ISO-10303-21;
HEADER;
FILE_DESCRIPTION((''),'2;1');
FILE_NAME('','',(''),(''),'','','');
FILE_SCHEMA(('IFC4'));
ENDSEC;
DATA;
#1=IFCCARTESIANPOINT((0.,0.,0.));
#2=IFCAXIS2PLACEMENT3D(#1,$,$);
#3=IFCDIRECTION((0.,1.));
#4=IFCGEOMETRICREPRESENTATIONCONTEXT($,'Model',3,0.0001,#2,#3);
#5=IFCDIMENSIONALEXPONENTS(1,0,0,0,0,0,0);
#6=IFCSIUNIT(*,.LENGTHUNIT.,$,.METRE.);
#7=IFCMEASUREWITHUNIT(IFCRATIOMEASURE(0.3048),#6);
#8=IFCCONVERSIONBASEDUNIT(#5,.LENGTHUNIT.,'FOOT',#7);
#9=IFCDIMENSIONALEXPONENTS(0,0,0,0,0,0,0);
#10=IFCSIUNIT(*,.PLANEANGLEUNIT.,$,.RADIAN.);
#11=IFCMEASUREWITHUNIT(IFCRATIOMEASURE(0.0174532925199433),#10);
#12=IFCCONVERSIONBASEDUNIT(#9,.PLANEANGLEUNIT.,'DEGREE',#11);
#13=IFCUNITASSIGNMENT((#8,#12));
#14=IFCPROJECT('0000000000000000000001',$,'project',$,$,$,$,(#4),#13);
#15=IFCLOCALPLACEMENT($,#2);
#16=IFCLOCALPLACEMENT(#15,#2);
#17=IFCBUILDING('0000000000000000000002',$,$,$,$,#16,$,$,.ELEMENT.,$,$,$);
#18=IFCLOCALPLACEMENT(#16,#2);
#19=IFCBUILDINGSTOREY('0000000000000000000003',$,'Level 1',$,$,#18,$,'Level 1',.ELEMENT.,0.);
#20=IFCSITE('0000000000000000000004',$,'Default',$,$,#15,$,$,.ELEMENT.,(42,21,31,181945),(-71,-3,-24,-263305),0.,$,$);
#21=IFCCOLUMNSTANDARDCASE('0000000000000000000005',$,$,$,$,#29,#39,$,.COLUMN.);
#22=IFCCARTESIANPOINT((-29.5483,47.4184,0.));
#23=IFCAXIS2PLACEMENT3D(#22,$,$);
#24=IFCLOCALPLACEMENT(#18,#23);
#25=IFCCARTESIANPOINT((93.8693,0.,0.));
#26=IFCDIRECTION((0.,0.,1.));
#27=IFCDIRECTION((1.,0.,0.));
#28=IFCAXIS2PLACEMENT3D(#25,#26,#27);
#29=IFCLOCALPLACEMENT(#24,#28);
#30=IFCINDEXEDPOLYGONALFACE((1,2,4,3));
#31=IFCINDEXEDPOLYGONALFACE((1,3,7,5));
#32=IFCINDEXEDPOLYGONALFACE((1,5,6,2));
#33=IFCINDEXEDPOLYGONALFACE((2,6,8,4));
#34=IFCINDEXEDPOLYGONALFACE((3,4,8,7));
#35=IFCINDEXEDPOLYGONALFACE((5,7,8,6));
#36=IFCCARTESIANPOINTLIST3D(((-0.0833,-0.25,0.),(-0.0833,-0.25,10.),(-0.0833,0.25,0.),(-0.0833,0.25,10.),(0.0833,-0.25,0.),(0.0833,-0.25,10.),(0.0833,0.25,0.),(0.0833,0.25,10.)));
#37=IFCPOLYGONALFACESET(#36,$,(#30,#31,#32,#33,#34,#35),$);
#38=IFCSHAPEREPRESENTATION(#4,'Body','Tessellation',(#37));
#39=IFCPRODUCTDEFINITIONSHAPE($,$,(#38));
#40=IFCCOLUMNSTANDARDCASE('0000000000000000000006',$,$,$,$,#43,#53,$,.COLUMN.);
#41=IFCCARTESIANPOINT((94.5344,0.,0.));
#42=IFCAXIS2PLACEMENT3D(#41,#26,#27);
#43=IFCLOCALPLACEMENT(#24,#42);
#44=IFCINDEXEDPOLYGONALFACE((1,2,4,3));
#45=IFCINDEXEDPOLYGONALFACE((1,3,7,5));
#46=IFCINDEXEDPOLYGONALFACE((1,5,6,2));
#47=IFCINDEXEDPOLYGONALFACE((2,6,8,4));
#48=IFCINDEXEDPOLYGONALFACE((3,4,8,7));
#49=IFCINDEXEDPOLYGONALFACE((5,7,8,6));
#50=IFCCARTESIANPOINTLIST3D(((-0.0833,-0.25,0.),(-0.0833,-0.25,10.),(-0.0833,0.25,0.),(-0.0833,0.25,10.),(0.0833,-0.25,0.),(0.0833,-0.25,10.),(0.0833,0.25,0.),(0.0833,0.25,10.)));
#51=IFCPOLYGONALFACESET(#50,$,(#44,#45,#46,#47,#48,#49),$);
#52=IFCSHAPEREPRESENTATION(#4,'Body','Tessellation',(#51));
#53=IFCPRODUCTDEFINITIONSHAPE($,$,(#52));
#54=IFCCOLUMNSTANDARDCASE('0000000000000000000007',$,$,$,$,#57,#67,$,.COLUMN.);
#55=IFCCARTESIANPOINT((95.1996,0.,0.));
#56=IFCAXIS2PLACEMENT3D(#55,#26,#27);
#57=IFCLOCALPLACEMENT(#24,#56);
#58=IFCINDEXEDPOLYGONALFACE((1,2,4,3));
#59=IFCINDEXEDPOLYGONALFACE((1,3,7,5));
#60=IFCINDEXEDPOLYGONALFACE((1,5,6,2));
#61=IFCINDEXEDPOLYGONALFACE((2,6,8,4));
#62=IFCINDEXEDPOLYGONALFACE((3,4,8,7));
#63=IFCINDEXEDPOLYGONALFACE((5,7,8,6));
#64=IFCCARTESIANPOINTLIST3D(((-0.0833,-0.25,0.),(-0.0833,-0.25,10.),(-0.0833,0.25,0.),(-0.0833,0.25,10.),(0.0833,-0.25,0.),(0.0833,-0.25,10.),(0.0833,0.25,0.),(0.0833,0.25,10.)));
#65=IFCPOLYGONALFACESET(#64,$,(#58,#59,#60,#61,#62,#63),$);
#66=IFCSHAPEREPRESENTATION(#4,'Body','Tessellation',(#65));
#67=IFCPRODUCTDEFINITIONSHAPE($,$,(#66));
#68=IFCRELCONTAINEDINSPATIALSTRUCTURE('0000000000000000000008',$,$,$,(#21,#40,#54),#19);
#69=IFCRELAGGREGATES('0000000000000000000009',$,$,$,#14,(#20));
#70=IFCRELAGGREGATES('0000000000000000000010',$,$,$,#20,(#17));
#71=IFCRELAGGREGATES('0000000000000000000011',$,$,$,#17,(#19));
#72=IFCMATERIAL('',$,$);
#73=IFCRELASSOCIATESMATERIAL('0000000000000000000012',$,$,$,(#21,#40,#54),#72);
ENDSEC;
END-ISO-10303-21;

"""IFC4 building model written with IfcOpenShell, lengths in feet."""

from ifc_helpers import new_model, entity, si_unit, converted_unit, direction, frame, origin, place, context, project, spatial, rectangle, extrude, material, element, save


model = new_model("IFC4")

# Units and contexts
model_context = context("Model", 3, precision=0.0001, world=origin(), true_north=direction((0.0, 1.0)))
ifc_project = project(units=[converted_unit("LENGTHUNIT", "FOOT", entity("IfcRatioMeasure", 0.3048), si_unit("LENGTHUNIT", "METRE"), dimensions=[1, 0, 0, 0, 0, 0, 0]), converted_unit("PLANEANGLEUNIT", "DEGREE", entity("IfcRatioMeasure", 0.0174532925199433), si_unit("PLANEANGLEUNIT", "RADIAN"), dimensions=[0, 0, 0, 0, 0, 0, 0])], contexts=[model_context])

# Site, building, storey
site_placement = place(None, origin())
site = spatial("IfcSite", under=ifc_project, at=site_placement, Name="Default", CompositionType="ELEMENT", RefLatitude=(42, 21, 31, 181945), RefLongitude=(-71, -3, -24, -263305), RefElevation=0.0)
building_placement = place(site_placement, origin())
building = spatial("IfcBuilding", under=site, at=building_placement, CompositionType="ELEMENT")
storey_placement = place(building_placement, origin())
storey = spatial("IfcBuildingStorey", under=building, at=storey_placement, Name="Level 1", LongName="Level 1", CompositionType="ELEMENT", Elevation=0.0)

# Columns
ifc_material = material(Name="")
placement = place(storey_placement, frame((-29.5483, 47.4184, 0.0)))
for number, where, z_axis, x_axis in (
    (1, (93.8693, 0.0, 0.0), (0.0, 0.0, 1.0), (1.0, 0.0, 0.0)),
    (2, (94.5344, 0.0, 0.0), (0.0, 0.0, 1.0), (1.0, 0.0, 0.0)),
    (3, (95.1996, 0.0, 0.0), (0.0, 0.0, 1.0), (1.0, 0.0, 0.0)),
):
    element("IfcColumnStandardCase", number, at=place(placement, frame(where, z_axis=z_axis, x_axis=x_axis)), inside=storey, material=ifc_material, PredefinedType="COLUMN", context=model_context, shape_type="SweptSolid", body=[
        extrude(rectangle(XDim=0.1667, YDim=0.5), origin(), (0.0, 0.0, 1.0), 10.0),
    ])

save(model, "model.ifc")
